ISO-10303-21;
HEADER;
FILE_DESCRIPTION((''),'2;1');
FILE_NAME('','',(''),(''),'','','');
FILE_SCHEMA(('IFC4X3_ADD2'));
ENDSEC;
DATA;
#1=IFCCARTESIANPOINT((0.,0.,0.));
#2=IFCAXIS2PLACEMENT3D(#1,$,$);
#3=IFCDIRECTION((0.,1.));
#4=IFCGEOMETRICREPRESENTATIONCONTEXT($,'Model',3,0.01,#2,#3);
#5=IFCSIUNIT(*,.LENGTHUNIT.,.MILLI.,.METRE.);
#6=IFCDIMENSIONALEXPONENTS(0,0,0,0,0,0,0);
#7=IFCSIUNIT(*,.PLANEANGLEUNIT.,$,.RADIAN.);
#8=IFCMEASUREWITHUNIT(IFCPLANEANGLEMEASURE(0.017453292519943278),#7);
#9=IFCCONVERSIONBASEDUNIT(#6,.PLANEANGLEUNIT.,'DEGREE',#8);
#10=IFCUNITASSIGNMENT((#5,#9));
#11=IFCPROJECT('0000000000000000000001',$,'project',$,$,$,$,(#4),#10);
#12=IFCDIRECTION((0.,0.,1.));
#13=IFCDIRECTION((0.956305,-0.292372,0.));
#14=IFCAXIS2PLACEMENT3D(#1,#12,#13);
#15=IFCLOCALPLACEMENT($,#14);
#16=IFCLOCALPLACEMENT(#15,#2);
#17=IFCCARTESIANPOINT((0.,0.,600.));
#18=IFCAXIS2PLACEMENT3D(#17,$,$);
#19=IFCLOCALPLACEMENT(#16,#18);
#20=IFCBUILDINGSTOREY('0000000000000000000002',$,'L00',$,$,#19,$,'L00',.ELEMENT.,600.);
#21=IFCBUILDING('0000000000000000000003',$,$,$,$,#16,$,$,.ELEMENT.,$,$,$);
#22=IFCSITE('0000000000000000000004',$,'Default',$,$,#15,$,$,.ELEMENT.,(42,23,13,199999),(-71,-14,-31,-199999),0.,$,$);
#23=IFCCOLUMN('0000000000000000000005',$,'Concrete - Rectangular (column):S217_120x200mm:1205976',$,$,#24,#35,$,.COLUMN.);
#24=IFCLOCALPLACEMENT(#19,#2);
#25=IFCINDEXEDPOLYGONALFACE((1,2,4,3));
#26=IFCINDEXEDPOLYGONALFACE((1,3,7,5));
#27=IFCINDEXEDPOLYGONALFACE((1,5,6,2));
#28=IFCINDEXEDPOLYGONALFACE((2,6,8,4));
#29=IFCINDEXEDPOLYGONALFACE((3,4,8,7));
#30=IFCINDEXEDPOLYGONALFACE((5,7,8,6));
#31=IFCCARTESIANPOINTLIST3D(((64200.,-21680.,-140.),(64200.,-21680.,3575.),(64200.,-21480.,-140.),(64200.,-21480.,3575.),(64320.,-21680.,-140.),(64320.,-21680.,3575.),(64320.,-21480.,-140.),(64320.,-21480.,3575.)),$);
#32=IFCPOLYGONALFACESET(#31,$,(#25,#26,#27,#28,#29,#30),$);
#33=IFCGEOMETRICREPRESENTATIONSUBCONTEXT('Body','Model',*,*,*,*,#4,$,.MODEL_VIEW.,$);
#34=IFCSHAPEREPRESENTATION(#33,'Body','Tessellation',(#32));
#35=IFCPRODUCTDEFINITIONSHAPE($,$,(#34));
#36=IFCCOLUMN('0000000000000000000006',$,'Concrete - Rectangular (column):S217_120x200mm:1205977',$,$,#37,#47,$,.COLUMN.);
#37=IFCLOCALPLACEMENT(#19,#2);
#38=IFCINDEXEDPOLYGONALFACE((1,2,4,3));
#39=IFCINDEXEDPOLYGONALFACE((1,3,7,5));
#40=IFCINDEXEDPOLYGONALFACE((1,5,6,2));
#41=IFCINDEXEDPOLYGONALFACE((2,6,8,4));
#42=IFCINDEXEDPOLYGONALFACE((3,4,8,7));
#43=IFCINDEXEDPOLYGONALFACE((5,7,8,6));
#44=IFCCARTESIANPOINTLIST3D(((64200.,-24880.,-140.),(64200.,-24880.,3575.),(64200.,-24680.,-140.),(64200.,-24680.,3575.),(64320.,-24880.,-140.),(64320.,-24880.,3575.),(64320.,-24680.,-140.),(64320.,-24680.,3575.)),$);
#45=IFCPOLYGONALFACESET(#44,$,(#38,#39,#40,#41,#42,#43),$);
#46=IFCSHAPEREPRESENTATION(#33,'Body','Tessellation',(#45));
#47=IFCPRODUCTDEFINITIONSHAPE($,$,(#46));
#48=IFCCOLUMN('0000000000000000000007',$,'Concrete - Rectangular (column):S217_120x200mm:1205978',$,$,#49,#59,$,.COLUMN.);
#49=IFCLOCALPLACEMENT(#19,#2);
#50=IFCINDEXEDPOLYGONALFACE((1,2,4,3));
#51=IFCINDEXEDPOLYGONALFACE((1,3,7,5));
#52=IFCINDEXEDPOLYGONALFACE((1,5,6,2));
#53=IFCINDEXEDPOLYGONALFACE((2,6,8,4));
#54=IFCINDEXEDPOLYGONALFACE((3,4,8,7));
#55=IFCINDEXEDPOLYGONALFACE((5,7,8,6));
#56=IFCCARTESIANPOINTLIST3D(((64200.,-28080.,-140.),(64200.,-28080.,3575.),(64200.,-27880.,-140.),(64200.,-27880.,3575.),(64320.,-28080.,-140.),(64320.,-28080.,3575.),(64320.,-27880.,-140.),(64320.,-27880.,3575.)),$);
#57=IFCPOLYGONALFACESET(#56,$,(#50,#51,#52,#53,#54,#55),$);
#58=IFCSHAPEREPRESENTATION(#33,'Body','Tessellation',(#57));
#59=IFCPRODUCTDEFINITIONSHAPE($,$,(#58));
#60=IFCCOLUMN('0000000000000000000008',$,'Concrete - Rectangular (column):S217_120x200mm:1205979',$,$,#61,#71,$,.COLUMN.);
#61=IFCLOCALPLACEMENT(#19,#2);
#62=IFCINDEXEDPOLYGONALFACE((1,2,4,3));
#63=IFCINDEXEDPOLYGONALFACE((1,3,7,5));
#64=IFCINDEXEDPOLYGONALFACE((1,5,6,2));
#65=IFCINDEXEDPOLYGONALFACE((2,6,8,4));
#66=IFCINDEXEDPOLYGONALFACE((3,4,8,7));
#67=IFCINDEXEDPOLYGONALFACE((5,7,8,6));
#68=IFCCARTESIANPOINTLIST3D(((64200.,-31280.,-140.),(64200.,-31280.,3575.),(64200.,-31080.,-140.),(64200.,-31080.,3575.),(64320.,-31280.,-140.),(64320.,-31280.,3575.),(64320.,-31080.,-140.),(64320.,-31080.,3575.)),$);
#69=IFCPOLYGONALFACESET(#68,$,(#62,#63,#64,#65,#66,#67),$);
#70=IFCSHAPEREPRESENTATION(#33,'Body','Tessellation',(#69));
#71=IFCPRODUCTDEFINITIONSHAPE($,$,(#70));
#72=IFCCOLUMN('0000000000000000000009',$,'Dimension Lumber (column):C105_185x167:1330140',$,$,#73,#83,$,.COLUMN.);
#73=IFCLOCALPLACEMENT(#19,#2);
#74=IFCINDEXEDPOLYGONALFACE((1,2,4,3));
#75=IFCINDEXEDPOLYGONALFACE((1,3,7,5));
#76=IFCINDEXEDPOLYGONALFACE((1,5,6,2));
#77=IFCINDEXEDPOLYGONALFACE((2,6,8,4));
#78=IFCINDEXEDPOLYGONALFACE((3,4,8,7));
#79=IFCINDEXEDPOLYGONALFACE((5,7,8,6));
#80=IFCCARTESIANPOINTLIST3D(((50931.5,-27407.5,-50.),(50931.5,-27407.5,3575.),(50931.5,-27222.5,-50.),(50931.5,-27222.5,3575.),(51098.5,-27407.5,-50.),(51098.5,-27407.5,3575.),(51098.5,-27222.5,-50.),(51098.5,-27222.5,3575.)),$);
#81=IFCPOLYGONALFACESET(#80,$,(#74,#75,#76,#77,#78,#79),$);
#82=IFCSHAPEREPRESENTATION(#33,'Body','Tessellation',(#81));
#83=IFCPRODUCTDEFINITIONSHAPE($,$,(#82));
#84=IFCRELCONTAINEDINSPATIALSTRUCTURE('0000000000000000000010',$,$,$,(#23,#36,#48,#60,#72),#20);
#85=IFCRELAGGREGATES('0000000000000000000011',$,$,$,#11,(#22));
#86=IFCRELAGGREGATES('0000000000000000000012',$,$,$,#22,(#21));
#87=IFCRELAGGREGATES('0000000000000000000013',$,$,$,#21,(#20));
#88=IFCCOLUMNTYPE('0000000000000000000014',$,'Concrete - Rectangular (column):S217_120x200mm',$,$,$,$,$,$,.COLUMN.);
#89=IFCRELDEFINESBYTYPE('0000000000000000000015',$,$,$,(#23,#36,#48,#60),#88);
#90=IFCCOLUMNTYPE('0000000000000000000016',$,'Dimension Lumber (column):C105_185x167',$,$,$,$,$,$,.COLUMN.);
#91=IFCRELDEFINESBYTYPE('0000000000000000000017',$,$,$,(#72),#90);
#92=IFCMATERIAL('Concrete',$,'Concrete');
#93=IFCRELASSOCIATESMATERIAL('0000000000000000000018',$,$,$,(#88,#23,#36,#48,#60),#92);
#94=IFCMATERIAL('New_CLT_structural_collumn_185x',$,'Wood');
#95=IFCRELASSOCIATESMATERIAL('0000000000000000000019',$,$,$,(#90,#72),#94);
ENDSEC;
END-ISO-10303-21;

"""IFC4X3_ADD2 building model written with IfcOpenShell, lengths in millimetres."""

from ifc_helpers import new_model, entity, si_unit, converted_unit, direction, frame, origin, origin_2d_with_axis, place, context, subcontext, project, spatial, rectangle, extrude, source, transform, mapped, material, material_profile, profile_set, profile_usage, type_object, type_shapes, element, save


model = new_model("IFC4X3_ADD2")

# Units and contexts
model_context = context("Model", 3, precision=0.01, world=origin(), true_north=direction((0.0, 1.0)))
body_context = subcontext(model_context, "Body", "Model", "MODEL_VIEW")
ifc_project = project(units=[si_unit("LENGTHUNIT", "METRE", prefix="MILLI"), converted_unit("PLANEANGLEUNIT", "DEGREE", entity("IfcPlaneAngleMeasure", 0.017453292519943278), si_unit("PLANEANGLEUNIT", "RADIAN"), dimensions=[0, 0, 0, 0, 0, 0, 0])], contexts=[model_context])

# Site, building, storey
site_placement = place(None, frame((0.0, 0.0, 0.0), z_axis=(0.0, 0.0, 1.0), x_axis=(0.956305, -0.292372, 0.0)))
site = spatial("IfcSite", under=ifc_project, at=site_placement, Name="Default", CompositionType="ELEMENT", RefLatitude=(42, 23, 13, 199999), RefLongitude=(-71, -14, -31, -199999), RefElevation=0.0)
building_placement = place(site_placement, origin())
building = spatial("IfcBuilding", under=site, at=building_placement, CompositionType="ELEMENT")
storey_placement = place(building_placement, frame((0.0, 0.0, 600.0)))
storey = spatial("IfcBuildingStorey", under=building, at=storey_placement, Name="L00", LongName="L00", CompositionType="ELEMENT", Elevation=600.0)

# Columns
ifc_material_1 = material(Name="Concrete", Category="Concrete")
ifc_material_profile_1 = material_profile(ifc_material_1, rectangle(XDim=120.0, YDim=200.0, at=origin_2d_with_axis()), Name="S217_120x200mm")
ifc_profile_set_1 = profile_set([ifc_material_profile_1], Name="S217_120x200mm")
ifc_profile_usage_1 = profile_usage(ifc_profile_set_1)
column_type_1 = type_object("IfcColumnType", Name="Concrete - Rectangular (column):S217_120x200mm", PredefinedType="COLUMN", material=ifc_profile_set_1)
shared_shape_1 = source(origin(), body_context, "Body", "SweptSolid", [
    extrude(rectangle(XDim=120.0, YDim=200.0, at=origin_2d_with_axis()), frame((0.0, 0.0, 460.0), z_axis=(0.0, 0.0, 1.0), x_axis=(-1.0, 0.0, 0.0)), (0.0, 0.0, 1.0), 3715.0),
])
type_shapes(column_type_1, [shared_shape_1])
for number, where, name in (
    (1, (64260.0, -21580.0, -600.0), "Concrete - Rectangular (column):S217_120x200mm:1205976"),
    (2, (64260.0, -24780.0, -600.0), "Concrete - Rectangular (column):S217_120x200mm:1205977"),
    (3, (64260.0, -27980.0, -600.0), "Concrete - Rectangular (column):S217_120x200mm:1205978"),
    (4, (64260.0, -31180.0, -600.0), "Concrete - Rectangular (column):S217_120x200mm:1205979"),
):
    element("IfcColumn", number, at=place(storey_placement, frame(where)), inside=storey, type_object=column_type_1, material=ifc_profile_usage_1, Name=name, PredefinedType="COLUMN", context=body_context, shape_type="MappedRepresentation", body=[
        mapped(shared_shape_1, transform((0.0, 0.0, 0.0), scale=1.0)),
    ])
ifc_material_2 = material(Name="New_CLT_structural_collumn_185x", Category="Wood")
ifc_material_profile_2 = material_profile(ifc_material_2, rectangle(XDim=185.0, YDim=167.0, at=origin_2d_with_axis()), Name="C105_185x167")
ifc_profile_set_2 = profile_set([ifc_material_profile_2], Name="C105_185x167")
ifc_profile_usage_2 = profile_usage(ifc_profile_set_2)
column_type_2 = type_object("IfcColumnType", Name="Dimension Lumber (column):C105_185x167", PredefinedType="COLUMN", material=ifc_profile_set_2)
shared_shape_2 = source(origin(), body_context, "Body", "SweptSolid", [
    extrude(rectangle(XDim=185.0, YDim=167.0, at=origin_2d_with_axis()), frame((0.0, 0.0, 550.0), z_axis=(0.0, 0.0, 1.0), x_axis=(-1.0, 0.0, 0.0)), (0.0, 0.0, 1.0), 3625.0),
])
type_shapes(column_type_2, [shared_shape_2])
column_placement = place(storey_placement, frame((51015.0, -27315.0, -600.0), z_axis=(0.0, 0.0, 1.0), x_axis=(0.0, 1.0, 0.0)))
element("IfcColumn", 5, at=column_placement, inside=storey, type_object=column_type_2, material=ifc_profile_usage_2, Name="Dimension Lumber (column):C105_185x167:1330140", PredefinedType="COLUMN", context=body_context, shape_type="MappedRepresentation", body=[
    mapped(shared_shape_2, transform((0.0, 0.0, 0.0), scale=1.0)),
])

save(model, "model.ifc")
